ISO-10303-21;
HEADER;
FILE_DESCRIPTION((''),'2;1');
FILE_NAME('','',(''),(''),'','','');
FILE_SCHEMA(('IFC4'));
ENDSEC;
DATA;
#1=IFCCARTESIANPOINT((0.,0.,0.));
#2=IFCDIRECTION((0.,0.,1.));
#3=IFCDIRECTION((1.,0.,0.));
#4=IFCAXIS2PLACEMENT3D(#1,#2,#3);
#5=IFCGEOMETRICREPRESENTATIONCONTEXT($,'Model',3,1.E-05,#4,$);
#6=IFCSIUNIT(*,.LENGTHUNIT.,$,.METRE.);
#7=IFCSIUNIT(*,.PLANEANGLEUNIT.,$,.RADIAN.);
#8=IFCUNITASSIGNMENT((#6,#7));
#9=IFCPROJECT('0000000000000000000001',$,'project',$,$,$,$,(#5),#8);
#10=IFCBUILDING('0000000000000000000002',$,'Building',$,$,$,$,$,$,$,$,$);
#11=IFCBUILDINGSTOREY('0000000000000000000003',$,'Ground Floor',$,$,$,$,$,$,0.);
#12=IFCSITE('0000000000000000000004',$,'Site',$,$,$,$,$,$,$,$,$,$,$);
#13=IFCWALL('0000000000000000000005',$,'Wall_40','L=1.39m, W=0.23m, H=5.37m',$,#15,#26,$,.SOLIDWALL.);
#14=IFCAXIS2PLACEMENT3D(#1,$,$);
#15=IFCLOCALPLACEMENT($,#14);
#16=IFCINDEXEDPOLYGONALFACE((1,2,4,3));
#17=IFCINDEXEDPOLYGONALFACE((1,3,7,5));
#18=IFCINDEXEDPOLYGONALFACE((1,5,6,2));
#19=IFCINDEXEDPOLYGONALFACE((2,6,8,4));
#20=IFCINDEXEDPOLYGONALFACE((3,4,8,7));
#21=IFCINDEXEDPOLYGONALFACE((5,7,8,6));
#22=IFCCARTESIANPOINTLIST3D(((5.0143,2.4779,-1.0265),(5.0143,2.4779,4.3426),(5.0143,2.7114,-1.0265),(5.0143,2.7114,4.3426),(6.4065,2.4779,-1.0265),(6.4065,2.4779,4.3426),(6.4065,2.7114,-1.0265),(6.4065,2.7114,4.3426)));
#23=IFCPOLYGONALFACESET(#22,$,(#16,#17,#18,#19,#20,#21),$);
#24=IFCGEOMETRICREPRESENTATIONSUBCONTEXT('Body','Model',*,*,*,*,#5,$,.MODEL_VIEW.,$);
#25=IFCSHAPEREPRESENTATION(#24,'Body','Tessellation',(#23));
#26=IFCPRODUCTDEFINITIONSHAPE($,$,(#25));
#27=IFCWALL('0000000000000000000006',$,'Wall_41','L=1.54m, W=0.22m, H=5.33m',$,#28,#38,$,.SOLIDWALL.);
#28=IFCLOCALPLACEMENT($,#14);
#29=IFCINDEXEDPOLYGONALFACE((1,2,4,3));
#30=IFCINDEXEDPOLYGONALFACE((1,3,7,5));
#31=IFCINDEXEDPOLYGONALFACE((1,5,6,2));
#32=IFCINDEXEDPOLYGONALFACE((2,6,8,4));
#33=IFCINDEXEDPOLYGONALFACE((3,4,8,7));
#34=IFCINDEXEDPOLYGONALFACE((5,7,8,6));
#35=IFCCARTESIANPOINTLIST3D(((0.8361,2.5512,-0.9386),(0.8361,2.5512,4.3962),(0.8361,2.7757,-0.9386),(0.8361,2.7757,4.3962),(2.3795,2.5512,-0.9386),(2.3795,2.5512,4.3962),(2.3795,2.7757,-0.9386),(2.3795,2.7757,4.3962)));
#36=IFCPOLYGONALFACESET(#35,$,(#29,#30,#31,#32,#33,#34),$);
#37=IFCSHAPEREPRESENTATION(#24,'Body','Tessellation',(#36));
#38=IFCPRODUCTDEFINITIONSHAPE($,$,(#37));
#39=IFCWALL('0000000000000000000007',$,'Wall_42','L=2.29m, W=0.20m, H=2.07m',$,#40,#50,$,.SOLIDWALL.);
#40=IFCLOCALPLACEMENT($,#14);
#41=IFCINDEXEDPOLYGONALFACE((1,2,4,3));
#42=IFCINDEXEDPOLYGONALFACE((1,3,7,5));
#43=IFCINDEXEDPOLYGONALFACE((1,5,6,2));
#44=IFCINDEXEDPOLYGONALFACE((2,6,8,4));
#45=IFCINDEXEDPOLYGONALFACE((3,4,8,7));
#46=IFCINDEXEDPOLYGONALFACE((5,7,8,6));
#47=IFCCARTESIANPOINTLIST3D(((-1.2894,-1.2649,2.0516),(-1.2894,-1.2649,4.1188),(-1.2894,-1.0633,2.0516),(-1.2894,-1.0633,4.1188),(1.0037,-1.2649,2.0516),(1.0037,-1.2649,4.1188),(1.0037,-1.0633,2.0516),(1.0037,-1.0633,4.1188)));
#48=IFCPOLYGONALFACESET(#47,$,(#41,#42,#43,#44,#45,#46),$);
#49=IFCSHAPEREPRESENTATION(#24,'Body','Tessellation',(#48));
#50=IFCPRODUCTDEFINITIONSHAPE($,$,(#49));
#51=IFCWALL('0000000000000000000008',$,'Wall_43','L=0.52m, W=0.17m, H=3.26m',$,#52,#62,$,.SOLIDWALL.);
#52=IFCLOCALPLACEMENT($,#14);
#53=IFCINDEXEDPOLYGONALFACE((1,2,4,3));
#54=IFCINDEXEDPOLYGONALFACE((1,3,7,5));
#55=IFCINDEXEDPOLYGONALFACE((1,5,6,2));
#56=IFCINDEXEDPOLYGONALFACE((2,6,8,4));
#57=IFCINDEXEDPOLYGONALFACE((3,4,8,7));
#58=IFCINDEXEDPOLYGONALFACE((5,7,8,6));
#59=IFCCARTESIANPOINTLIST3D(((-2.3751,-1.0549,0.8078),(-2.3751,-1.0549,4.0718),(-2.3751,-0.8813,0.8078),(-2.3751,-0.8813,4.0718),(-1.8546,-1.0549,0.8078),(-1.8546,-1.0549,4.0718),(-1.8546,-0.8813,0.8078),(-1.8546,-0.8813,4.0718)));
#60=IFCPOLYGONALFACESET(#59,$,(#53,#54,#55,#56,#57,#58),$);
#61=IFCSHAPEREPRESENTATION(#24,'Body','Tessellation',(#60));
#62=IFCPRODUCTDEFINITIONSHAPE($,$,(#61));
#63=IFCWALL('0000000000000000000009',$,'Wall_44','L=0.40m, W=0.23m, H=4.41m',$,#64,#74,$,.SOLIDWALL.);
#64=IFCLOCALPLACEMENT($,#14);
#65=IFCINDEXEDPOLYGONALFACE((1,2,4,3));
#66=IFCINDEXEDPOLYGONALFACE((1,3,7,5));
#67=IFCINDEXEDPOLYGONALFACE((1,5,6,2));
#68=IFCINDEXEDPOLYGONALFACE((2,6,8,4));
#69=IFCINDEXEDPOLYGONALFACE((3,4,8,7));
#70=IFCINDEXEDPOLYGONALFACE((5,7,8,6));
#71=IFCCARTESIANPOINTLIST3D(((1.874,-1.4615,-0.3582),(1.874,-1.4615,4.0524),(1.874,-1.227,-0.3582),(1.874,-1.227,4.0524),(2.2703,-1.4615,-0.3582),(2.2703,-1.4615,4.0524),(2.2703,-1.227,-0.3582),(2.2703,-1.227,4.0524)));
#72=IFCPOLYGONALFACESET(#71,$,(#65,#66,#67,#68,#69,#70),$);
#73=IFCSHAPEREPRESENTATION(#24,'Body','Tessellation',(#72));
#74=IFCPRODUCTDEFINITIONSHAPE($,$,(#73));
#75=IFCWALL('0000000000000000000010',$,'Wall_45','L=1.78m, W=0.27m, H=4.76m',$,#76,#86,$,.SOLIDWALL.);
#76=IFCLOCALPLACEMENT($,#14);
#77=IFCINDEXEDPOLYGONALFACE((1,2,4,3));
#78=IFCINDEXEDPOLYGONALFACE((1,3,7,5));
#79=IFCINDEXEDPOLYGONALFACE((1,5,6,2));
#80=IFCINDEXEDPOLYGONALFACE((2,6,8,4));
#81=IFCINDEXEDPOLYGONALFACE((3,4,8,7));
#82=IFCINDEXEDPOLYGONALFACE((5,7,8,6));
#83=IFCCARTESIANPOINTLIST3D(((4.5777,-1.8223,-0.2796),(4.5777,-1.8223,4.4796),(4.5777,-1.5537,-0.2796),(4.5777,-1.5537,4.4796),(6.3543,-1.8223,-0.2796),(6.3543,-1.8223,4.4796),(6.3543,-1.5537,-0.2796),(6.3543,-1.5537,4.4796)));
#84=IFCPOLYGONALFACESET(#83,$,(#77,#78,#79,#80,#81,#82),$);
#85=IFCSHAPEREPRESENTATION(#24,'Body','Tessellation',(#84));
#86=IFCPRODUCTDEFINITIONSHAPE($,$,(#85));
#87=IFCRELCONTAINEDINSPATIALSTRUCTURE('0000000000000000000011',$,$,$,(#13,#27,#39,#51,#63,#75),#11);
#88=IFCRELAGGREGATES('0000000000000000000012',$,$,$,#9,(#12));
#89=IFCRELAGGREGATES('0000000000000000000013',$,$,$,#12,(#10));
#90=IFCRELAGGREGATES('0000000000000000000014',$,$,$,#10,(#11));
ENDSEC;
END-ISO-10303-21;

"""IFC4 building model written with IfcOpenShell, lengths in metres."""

from ifc_helpers import new_model, si_unit, frame, origin_with_axes, origin_2d, context, subcontext, project, spatial, rectangle, extrude, element, save


model = new_model("IFC4")

# Units and contexts
model_context = context("Model", 3, precision=1e-05, world=origin_with_axes())
body_context = subcontext(model_context, "Body", "Model", "MODEL_VIEW")
ifc_project = project(units=[si_unit("LENGTHUNIT", "METRE"), si_unit("PLANEANGLEUNIT", "RADIAN")], contexts=[model_context])

# Site, building, storey
site = spatial("IfcSite", under=ifc_project, Name="Site")
building = spatial("IfcBuilding", under=site, Name="Building")
storey = spatial("IfcBuildingStorey", under=building, Name="Ground Floor", Elevation=0.0)

# Walls
element("IfcWall", 1, inside=storey, Name="Wall_40", Description="L=1.39m, W=0.23m, H=5.37m", PredefinedType="SOLIDWALL", context=body_context, shape_type="SweptSolid", body=[
    extrude(rectangle(XDim=1.3922, YDim=0.2334, at=origin_2d()), frame((5.7104, 2.5946, -1.0265), z_axis=(0.0, 0.0, 1.0), x_axis=(1.0, 0.0, 0.0)), (0.0, 0.0, 1.0), 5.369),
])
element("IfcWall", 2, inside=storey, Name="Wall_41", Description="L=1.54m, W=0.22m, H=5.33m", PredefinedType="SOLIDWALL", context=body_context, shape_type="SweptSolid", body=[
    extrude(rectangle(XDim=1.5434, YDim=0.2246, at=origin_2d()), frame((1.6078, 2.6634, -0.9386), z_axis=(0.0, 0.0, 1.0), x_axis=(1.0, 0.0, 0.0)), (0.0, 0.0, 1.0), 5.3348),
])
element("IfcWall", 3, inside=storey, Name="Wall_42", Description="L=2.29m, W=0.20m, H=2.07m", PredefinedType="SOLIDWALL", context=body_context, shape_type="SweptSolid", body=[
    extrude(rectangle(XDim=2.293, YDim=0.2016, at=origin_2d()), frame((-0.1429, -1.1641, 2.0516), z_axis=(0.0, 0.0, 1.0), x_axis=(1.0, 0.0, 0.0)), (0.0, 0.0, 1.0), 2.0672),
])
element("IfcWall", 4, inside=storey, Name="Wall_43", Description="L=0.52m, W=0.17m, H=3.26m", PredefinedType="SOLIDWALL", context=body_context, shape_type="SweptSolid", body=[
    extrude(rectangle(XDim=0.5205, YDim=0.1736, at=origin_2d()), frame((-2.1148, -0.9681, 0.8078), z_axis=(0.0, 0.0, 1.0), x_axis=(1.0, 0.0, 0.0)), (0.0, 0.0, 1.0), 3.264),
])
element("IfcWall", 5, inside=storey, Name="Wall_44", Description="L=0.40m, W=0.23m, H=4.41m", PredefinedType="SOLIDWALL", context=body_context, shape_type="SweptSolid", body=[
    extrude(rectangle(XDim=0.3962, YDim=0.2344, at=origin_2d()), frame((2.0721, -1.3442, -0.3582), z_axis=(0.0, 0.0, 1.0), x_axis=(1.0, 0.0, 0.0)), (0.0, 0.0, 1.0), 4.4106),
])
element("IfcWall", 6, inside=storey, Name="Wall_45", Description="L=1.78m, W=0.27m, H=4.76m", PredefinedType="SOLIDWALL", context=body_context, shape_type="SweptSolid", body=[
    extrude(rectangle(XDim=1.7765, YDim=0.2686, at=origin_2d()), frame((5.466, -1.688, -0.2796), z_axis=(0.0, 0.0, 1.0), x_axis=(1.0, 0.0, 0.0)), (0.0, 0.0, 1.0), 4.7592),
])

save(model, "model.ifc")
